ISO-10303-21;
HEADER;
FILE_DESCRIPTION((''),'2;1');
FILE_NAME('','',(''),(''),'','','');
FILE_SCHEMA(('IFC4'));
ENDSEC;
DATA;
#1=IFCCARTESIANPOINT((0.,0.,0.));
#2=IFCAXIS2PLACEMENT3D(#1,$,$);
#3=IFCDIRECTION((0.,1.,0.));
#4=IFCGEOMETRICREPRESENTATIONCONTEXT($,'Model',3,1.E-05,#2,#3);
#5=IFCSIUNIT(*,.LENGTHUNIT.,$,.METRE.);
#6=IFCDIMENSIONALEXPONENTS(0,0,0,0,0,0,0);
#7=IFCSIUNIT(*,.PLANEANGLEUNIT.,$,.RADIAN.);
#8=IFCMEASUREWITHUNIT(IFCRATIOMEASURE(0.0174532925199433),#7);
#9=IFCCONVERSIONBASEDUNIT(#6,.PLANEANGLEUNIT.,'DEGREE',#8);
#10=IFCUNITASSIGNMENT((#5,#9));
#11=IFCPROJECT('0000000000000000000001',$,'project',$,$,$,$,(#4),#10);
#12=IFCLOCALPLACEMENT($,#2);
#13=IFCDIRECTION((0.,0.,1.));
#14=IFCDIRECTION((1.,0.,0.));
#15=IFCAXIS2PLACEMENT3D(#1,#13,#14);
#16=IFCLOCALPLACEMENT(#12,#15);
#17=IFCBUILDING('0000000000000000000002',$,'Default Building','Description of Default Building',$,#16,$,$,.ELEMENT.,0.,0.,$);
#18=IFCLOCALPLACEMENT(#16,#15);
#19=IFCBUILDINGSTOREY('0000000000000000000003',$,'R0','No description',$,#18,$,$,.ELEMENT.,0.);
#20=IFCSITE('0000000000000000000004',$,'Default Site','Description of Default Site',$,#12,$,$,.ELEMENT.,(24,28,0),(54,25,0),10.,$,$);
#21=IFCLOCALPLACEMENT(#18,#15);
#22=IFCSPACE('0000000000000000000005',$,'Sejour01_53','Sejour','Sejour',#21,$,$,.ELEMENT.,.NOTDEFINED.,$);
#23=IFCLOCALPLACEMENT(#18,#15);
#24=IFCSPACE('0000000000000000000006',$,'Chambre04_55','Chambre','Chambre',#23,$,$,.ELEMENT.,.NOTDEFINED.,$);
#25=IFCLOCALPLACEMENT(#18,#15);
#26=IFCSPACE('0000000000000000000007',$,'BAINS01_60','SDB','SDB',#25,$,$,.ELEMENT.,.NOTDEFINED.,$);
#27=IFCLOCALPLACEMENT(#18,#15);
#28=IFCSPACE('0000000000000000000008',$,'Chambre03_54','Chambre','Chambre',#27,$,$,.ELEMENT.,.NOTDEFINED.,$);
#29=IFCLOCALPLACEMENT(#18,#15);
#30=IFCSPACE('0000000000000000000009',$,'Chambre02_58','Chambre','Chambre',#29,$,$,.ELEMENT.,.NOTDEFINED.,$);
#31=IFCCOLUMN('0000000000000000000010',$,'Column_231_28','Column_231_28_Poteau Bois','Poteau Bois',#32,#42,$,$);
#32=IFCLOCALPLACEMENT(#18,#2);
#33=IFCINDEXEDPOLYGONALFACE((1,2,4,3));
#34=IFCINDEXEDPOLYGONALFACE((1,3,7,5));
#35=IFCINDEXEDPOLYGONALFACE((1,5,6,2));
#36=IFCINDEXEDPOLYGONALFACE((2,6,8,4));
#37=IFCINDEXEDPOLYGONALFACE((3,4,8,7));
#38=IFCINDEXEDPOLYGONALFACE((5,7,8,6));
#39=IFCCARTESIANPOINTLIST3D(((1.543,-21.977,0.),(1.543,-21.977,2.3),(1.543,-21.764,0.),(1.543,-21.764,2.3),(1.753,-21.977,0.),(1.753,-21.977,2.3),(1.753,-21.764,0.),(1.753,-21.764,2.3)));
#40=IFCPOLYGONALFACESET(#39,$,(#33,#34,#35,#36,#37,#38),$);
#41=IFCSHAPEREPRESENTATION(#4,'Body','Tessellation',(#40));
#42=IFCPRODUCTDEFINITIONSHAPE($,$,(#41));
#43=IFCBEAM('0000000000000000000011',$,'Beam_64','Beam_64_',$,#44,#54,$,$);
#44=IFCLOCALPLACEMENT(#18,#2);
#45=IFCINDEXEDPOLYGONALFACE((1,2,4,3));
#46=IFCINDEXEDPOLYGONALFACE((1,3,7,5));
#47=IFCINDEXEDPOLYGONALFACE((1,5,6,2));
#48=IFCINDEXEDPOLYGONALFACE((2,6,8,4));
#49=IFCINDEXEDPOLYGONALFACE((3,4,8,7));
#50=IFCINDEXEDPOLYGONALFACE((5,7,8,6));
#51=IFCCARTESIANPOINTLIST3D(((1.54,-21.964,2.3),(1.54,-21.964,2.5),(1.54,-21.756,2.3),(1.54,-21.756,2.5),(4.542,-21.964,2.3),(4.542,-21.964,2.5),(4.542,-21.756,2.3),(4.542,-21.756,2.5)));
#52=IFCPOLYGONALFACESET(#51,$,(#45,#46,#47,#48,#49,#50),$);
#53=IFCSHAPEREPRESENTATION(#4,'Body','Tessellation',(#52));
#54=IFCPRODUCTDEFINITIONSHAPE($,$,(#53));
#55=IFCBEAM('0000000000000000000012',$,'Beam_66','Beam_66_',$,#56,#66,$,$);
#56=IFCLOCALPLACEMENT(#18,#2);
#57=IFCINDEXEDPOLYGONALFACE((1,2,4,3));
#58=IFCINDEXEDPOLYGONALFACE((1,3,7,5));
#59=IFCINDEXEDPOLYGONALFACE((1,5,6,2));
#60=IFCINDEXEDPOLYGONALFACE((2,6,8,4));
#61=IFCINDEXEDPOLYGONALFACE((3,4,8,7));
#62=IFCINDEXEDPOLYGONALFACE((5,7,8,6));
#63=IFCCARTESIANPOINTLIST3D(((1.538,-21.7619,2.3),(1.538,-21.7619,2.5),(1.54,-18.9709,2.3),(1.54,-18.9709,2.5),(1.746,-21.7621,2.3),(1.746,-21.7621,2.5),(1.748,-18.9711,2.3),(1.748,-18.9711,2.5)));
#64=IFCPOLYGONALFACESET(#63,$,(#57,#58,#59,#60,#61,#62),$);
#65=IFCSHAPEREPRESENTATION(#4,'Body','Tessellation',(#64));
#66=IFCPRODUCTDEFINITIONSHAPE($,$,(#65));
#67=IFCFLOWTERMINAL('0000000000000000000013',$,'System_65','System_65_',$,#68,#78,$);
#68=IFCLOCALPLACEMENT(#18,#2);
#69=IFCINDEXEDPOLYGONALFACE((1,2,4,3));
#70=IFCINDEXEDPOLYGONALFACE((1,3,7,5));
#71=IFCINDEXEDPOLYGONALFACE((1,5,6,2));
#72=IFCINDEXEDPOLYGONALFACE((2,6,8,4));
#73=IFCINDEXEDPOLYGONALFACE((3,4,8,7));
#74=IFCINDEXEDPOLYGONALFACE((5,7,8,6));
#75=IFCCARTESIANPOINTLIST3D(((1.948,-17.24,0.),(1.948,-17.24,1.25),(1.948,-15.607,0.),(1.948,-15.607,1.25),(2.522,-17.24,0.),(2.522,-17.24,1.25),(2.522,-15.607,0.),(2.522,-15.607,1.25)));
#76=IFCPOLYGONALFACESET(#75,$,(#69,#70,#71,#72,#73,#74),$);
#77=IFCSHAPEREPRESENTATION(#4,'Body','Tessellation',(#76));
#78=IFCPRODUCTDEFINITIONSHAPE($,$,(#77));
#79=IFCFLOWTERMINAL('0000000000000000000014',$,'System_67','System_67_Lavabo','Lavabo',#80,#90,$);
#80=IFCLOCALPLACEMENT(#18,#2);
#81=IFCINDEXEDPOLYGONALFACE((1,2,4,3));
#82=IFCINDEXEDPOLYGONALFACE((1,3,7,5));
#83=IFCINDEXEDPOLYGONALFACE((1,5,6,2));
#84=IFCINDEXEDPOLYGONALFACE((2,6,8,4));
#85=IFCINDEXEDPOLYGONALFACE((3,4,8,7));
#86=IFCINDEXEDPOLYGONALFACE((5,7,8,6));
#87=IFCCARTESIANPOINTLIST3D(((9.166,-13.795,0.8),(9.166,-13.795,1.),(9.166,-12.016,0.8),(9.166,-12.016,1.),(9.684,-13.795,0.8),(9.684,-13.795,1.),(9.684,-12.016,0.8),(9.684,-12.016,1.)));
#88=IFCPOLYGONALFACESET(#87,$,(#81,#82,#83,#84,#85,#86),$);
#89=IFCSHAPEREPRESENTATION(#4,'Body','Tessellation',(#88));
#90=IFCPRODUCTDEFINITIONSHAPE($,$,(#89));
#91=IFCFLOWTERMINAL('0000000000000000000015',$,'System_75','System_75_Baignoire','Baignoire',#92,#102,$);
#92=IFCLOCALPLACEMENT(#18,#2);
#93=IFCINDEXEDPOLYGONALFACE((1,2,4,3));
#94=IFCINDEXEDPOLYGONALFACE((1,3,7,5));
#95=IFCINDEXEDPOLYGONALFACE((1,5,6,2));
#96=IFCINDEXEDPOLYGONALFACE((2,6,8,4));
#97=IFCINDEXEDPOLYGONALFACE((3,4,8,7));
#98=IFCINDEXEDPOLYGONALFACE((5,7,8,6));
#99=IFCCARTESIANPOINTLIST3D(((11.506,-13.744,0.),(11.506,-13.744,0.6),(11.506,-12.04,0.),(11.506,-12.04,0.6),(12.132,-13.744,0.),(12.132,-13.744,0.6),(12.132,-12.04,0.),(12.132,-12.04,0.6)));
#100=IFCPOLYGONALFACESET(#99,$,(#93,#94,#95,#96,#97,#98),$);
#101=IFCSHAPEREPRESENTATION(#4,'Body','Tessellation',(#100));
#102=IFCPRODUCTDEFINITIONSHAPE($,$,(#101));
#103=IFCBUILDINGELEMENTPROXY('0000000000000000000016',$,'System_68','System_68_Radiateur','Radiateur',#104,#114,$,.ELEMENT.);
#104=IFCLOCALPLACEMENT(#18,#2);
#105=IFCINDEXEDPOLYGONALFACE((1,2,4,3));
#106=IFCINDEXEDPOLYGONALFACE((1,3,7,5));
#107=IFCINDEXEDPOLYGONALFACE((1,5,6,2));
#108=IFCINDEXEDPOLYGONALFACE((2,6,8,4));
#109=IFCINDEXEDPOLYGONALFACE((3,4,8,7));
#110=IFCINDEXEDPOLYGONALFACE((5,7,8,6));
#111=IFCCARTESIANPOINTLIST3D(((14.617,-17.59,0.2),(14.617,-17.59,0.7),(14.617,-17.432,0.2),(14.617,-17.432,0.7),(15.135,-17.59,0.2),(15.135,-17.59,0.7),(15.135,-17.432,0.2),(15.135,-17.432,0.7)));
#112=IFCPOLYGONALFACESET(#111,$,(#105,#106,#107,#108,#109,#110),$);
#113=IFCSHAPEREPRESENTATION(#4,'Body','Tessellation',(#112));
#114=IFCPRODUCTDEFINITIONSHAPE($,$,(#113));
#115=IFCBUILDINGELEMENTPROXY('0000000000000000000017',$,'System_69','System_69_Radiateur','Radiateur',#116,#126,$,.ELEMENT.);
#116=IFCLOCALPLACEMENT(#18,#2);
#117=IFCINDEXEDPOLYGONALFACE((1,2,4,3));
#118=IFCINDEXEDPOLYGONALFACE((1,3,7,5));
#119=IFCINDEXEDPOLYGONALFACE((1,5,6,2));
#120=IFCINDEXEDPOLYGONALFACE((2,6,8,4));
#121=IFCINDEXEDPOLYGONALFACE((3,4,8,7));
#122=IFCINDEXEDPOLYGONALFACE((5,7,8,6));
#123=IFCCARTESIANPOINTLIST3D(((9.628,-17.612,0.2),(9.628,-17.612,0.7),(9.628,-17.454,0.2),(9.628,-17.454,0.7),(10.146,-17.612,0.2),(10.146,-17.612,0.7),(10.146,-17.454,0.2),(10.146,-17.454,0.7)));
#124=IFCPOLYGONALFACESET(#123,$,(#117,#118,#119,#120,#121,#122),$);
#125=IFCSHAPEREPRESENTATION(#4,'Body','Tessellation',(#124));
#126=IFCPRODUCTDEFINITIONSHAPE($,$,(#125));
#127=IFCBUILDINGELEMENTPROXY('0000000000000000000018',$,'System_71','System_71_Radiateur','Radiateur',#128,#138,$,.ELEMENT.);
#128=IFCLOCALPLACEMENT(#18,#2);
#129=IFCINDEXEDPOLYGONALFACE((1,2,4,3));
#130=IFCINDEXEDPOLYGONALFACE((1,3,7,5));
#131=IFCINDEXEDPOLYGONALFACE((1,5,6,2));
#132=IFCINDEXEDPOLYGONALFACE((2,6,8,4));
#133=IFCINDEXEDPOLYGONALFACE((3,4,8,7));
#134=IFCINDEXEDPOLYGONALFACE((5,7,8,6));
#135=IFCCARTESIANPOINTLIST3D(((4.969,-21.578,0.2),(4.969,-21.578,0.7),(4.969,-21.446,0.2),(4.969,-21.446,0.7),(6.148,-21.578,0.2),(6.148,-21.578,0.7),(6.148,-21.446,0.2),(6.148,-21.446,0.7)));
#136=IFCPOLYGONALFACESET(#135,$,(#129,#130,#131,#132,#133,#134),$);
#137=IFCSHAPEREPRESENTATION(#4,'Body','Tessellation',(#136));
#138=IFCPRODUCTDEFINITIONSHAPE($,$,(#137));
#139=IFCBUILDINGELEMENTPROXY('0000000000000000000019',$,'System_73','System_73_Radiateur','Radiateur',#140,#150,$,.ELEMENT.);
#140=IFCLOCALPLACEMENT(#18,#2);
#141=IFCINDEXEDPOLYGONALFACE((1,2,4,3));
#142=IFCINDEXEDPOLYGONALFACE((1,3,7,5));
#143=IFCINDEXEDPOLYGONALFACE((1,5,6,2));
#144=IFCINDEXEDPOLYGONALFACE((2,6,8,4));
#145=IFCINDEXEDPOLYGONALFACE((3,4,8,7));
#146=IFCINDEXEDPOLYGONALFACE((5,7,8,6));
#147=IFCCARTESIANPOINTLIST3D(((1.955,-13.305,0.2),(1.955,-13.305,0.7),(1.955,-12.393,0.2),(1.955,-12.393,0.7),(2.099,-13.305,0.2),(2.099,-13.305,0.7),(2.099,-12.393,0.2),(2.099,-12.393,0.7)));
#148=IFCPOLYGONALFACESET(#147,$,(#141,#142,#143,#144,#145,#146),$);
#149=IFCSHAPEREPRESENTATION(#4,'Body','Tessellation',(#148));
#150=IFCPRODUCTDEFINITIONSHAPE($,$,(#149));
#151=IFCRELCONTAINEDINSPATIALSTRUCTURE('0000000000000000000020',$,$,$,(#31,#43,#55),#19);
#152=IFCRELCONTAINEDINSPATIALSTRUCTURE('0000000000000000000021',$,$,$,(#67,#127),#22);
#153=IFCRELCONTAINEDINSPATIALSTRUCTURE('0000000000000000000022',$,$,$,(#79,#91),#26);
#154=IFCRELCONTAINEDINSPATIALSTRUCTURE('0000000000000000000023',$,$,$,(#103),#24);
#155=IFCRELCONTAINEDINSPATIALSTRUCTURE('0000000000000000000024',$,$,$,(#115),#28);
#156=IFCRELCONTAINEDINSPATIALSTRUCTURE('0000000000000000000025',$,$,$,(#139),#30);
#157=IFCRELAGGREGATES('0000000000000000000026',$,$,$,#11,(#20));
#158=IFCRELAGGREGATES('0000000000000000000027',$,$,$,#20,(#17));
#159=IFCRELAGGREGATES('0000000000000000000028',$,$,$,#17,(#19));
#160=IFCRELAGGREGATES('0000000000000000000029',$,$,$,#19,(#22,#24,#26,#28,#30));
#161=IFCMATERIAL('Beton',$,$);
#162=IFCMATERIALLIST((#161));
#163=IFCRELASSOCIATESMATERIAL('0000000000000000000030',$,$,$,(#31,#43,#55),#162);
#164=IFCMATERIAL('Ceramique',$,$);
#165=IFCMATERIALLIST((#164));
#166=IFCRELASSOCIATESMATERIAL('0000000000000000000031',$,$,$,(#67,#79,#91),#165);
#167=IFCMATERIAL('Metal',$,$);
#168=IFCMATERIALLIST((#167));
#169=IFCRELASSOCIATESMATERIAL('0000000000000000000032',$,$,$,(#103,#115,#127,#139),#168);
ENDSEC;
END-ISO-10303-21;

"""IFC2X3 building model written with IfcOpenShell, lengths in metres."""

from ifc_helpers import new_model, entity, si_unit, converted_unit, direction, frame, origin, origin_with_axes, place, context, project, spatial, polyline, outline, extrude, material, material_list, element, save


model = new_model("IFC2X3")

# Units and contexts
model_context = context("Model", 3, precision=1e-05, world=origin(), true_north=direction((0.0, 1.0, 0.0)))
ifc_project = project(units=[si_unit("LENGTHUNIT", "METRE"), converted_unit("PLANEANGLEUNIT", "DEGREE", entity("IfcRatioMeasure", 0.0174532925199433), si_unit("PLANEANGLEUNIT", "RADIAN"), dimensions=[0, 0, 0, 0, 0, 0, 0])], contexts=[model_context])

# Site, building, storey
site_placement = place(None, origin())
site = spatial("IfcSite", under=ifc_project, at=site_placement, Name="Default Site", Description="Description of Default Site", CompositionType="ELEMENT", RefLatitude=(24, 28, 0), RefLongitude=(54, 25, 0), RefElevation=10.0)
building_placement = place(site_placement, origin_with_axes())
building = spatial("IfcBuilding", under=site, at=building_placement, Name="Default Building", Description="Description of Default Building", CompositionType="ELEMENT", ElevationOfRefHeight=0.0, ElevationOfTerrain=0.0)
storey_placement = place(building_placement, origin_with_axes())
storey = spatial("IfcBuildingStorey", under=building, at=storey_placement, Name="R0", Description="No description", CompositionType="ELEMENT", Elevation=0.0)

# Column
ifc_material_1 = material(Name="Beton")
ifc_material_list_1 = material_list([ifc_material_1])
column_placement = place(storey_placement, frame((1.648, -21.977, 0.0), z_axis=(0.0, 0.0, 1.0), x_axis=(0.0, 0.213, 0.0)))
element("IfcColumn", 1, at=column_placement, inside=storey, material=ifc_material_list_1, Name="Column_231_28", Description="Column_231_28_Poteau Bois", ObjectType="Poteau Bois", context=model_context, shape_type="SweptSolid", body=[
    extrude(outline(polyline([(0.0, -0.105), (0.213, -0.105), (0.213, 0.105), (0.0, 0.105), (0.0, -0.105)])), origin(), (0.0, 0.0, 1.0), 2.3),
])

# Beams
beam_1_placement = place(storey_placement, frame((1.54, -21.86, 2.3), z_axis=(0.0, 0.0, 1.0), x_axis=(3.002, 0.0, 0.0)))
element("IfcBeam", 2, at=beam_1_placement, inside=storey, material=ifc_material_list_1, Name="Beam_64", Description="Beam_64_", context=model_context, shape_type="SweptSolid", body=[
    extrude(outline(polyline([(0.0, -0.104), (3.002, -0.104), (3.002, 0.104), (0.0, 0.104), (0.0, -0.104)])), origin(), (0.0, 0.0, 1.0), 0.2),
])
beam_2_placement = place(storey_placement, frame((1.644, -18.971, 2.3), z_axis=(0.0, 0.0, 1.0), x_axis=(-0.002, -2.791, 0.0)))
element("IfcBeam", 3, at=beam_2_placement, inside=storey, material=ifc_material_list_1, Name="Beam_66", Description="Beam_66_", context=model_context, shape_type="SweptSolid", body=[
    extrude(outline(polyline([(0.0, -0.104), (2.791, -0.104), (2.791, 0.104), (0.0, 0.104), (0.0, -0.104)])), origin(), (0.0, 0.0, 1.0), 0.2),
])

# Shared definitions
space_1_placement = place(storey_placement, origin_with_axes())
space_1 = spatial("IfcSpace", under=storey, at=space_1_placement, Name="Sejour01_53", Description="Sejour", ObjectType="Sejour", CompositionType="ELEMENT", InteriorOrExteriorSpace="NOTDEFINED")

# Shared definitions
space_2_placement = place(storey_placement, origin_with_axes())
space_2 = spatial("IfcSpace", under=storey, at=space_2_placement, Name="Chambre04_55", Description="Chambre", ObjectType="Chambre", CompositionType="ELEMENT", InteriorOrExteriorSpace="NOTDEFINED")

# Flow terminal
ifc_material_2 = material(Name="Ceramique")
ifc_material_list_2 = material_list([ifc_material_2])
flow_terminal_1_placement = place(storey_placement, frame((2.235, -17.24, 0.0), z_axis=(0.0, 0.0, 1.0), x_axis=(0.0, 1.633, 0.0)))
element("IfcFlowTerminal", 4, at=flow_terminal_1_placement, inside=space_1, material=ifc_material_list_2, Name="System_65", Description="System_65_", context=model_context, shape_type="SweptSolid", body=[
    extrude(outline(polyline([(0.0, -0.287), (1.633, -0.287), (1.633, 0.287), (0.0, 0.287), (0.0, -0.287)])), origin(), (0.0, 0.0, 1.0), 1.25),
])

# Shared definitions
space_3_placement = place(storey_placement, origin_with_axes())
space_3 = spatial("IfcSpace", under=storey, at=space_3_placement, Name="BAINS01_60", Description="SDB", ObjectType="SDB", CompositionType="ELEMENT", InteriorOrExteriorSpace="NOTDEFINED")

# Flow terminals
flow_terminal_2_placement = place(storey_placement, frame((9.425, -13.795, 0.8), z_axis=(0.0, 0.0, 1.0), x_axis=(0.0, 1.779, 0.0)))
element("IfcFlowTerminal", 5, at=flow_terminal_2_placement, inside=space_3, material=ifc_material_list_2, Name="System_67", Description="System_67_Lavabo", ObjectType="Lavabo", context=model_context, shape_type="SweptSolid", body=[
    extrude(outline(polyline([(0.0, -0.259), (1.779, -0.259), (1.779, 0.259), (0.0, 0.259), (0.0, -0.259)])), origin(), (0.0, 0.0, 1.0), 0.2),
])
flow_terminal_3_placement = place(storey_placement, frame((11.819, -13.744, 0.0), z_axis=(0.0, 0.0, 1.0), x_axis=(0.0, 1.704, 0.0)))
element("IfcFlowTerminal", 6, at=flow_terminal_3_placement, inside=space_3, material=ifc_material_list_2, Name="System_75", Description="System_75_Baignoire", ObjectType="Baignoire", context=model_context, shape_type="SweptSolid", body=[
    extrude(outline(polyline([(0.0, -0.313), (1.704, -0.313), (1.704, 0.313), (0.0, 0.313), (0.0, -0.313)])), origin(), (0.0, 0.0, 1.0), 0.6),
])

# Building element proxy
ifc_material_3 = material(Name="Metal")
ifc_material_list_3 = material_list([ifc_material_3])
proxy_1_placement = place(storey_placement, frame((14.617, -17.511, 0.2), z_axis=(0.0, 0.0, 1.0), x_axis=(0.518, 0.0, 0.0)))
element("IfcBuildingElementProxy", 7, at=proxy_1_placement, inside=space_2, material=ifc_material_list_3, Name="System_68", Description="System_68_Radiateur", ObjectType="Radiateur", CompositionType="ELEMENT", context=model_context, shape_type="SweptSolid", body=[
    extrude(outline(polyline([(0.0, -0.079), (0.518, -0.079), (0.518, 0.079), (0.0, 0.079), (0.0, -0.079)])), origin(), (0.0, 0.0, 1.0), 0.5),
])

# Shared definitions
space_4_placement = place(storey_placement, origin_with_axes())
space_4 = spatial("IfcSpace", under=storey, at=space_4_placement, Name="Chambre03_54", Description="Chambre", ObjectType="Chambre", CompositionType="ELEMENT", InteriorOrExteriorSpace="NOTDEFINED")

# Building element proxies
proxy_2_placement = place(storey_placement, frame((9.628, -17.533, 0.2), z_axis=(0.0, 0.0, 1.0), x_axis=(0.518, 0.0, 0.0)))
element("IfcBuildingElementProxy", 8, at=proxy_2_placement, inside=space_4, material=ifc_material_list_3, Name="System_69", Description="System_69_Radiateur", ObjectType="Radiateur", CompositionType="ELEMENT", context=model_context, shape_type="SweptSolid", body=[
    extrude(outline(polyline([(0.0, -0.079), (0.518, -0.079), (0.518, 0.079), (0.0, 0.079), (0.0, -0.079)])), origin(), (0.0, 0.0, 1.0), 0.5),
])
proxy_3_placement = place(storey_placement, frame((4.969, -21.512, 0.2), z_axis=(0.0, 0.0, 1.0), x_axis=(1.179, 0.0, 0.0)))
element("IfcBuildingElementProxy", 9, at=proxy_3_placement, inside=space_1, material=ifc_material_list_3, Name="System_71", Description="System_71_Radiateur", ObjectType="Radiateur", CompositionType="ELEMENT", context=model_context, shape_type="SweptSolid", body=[
    extrude(outline(polyline([(0.0, -0.066), (1.179, -0.066), (1.179, 0.066), (0.0, 0.066), (0.0, -0.066)])), origin(), (0.0, 0.0, 1.0), 0.5),
])

# Shared definitions
space_5_placement = place(storey_placement, origin_with_axes())
space_5 = spatial("IfcSpace", under=storey, at=space_5_placement, Name="Chambre02_58", Description="Chambre", ObjectType="Chambre", CompositionType="ELEMENT", InteriorOrExteriorSpace="NOTDEFINED")

# Building element proxy
proxy_4_placement = place(storey_placement, frame((2.027, -13.305, 0.2), z_axis=(0.0, 0.0, 1.0), x_axis=(0.0, 0.912, 0.0)))
element("IfcBuildingElementProxy", 10, at=proxy_4_placement, inside=space_5, material=ifc_material_list_3, Name="System_73", Description="System_73_Radiateur", ObjectType="Radiateur", CompositionType="ELEMENT", context=model_context, shape_type="SweptSolid", body=[
    extrude(outline(polyline([(0.0, -0.072), (0.912, -0.072), (0.912, 0.072), (0.0, 0.072), (0.0, -0.072)])), origin(), (0.0, 0.0, 1.0), 0.5),
])

save(model, "model.ifc")
